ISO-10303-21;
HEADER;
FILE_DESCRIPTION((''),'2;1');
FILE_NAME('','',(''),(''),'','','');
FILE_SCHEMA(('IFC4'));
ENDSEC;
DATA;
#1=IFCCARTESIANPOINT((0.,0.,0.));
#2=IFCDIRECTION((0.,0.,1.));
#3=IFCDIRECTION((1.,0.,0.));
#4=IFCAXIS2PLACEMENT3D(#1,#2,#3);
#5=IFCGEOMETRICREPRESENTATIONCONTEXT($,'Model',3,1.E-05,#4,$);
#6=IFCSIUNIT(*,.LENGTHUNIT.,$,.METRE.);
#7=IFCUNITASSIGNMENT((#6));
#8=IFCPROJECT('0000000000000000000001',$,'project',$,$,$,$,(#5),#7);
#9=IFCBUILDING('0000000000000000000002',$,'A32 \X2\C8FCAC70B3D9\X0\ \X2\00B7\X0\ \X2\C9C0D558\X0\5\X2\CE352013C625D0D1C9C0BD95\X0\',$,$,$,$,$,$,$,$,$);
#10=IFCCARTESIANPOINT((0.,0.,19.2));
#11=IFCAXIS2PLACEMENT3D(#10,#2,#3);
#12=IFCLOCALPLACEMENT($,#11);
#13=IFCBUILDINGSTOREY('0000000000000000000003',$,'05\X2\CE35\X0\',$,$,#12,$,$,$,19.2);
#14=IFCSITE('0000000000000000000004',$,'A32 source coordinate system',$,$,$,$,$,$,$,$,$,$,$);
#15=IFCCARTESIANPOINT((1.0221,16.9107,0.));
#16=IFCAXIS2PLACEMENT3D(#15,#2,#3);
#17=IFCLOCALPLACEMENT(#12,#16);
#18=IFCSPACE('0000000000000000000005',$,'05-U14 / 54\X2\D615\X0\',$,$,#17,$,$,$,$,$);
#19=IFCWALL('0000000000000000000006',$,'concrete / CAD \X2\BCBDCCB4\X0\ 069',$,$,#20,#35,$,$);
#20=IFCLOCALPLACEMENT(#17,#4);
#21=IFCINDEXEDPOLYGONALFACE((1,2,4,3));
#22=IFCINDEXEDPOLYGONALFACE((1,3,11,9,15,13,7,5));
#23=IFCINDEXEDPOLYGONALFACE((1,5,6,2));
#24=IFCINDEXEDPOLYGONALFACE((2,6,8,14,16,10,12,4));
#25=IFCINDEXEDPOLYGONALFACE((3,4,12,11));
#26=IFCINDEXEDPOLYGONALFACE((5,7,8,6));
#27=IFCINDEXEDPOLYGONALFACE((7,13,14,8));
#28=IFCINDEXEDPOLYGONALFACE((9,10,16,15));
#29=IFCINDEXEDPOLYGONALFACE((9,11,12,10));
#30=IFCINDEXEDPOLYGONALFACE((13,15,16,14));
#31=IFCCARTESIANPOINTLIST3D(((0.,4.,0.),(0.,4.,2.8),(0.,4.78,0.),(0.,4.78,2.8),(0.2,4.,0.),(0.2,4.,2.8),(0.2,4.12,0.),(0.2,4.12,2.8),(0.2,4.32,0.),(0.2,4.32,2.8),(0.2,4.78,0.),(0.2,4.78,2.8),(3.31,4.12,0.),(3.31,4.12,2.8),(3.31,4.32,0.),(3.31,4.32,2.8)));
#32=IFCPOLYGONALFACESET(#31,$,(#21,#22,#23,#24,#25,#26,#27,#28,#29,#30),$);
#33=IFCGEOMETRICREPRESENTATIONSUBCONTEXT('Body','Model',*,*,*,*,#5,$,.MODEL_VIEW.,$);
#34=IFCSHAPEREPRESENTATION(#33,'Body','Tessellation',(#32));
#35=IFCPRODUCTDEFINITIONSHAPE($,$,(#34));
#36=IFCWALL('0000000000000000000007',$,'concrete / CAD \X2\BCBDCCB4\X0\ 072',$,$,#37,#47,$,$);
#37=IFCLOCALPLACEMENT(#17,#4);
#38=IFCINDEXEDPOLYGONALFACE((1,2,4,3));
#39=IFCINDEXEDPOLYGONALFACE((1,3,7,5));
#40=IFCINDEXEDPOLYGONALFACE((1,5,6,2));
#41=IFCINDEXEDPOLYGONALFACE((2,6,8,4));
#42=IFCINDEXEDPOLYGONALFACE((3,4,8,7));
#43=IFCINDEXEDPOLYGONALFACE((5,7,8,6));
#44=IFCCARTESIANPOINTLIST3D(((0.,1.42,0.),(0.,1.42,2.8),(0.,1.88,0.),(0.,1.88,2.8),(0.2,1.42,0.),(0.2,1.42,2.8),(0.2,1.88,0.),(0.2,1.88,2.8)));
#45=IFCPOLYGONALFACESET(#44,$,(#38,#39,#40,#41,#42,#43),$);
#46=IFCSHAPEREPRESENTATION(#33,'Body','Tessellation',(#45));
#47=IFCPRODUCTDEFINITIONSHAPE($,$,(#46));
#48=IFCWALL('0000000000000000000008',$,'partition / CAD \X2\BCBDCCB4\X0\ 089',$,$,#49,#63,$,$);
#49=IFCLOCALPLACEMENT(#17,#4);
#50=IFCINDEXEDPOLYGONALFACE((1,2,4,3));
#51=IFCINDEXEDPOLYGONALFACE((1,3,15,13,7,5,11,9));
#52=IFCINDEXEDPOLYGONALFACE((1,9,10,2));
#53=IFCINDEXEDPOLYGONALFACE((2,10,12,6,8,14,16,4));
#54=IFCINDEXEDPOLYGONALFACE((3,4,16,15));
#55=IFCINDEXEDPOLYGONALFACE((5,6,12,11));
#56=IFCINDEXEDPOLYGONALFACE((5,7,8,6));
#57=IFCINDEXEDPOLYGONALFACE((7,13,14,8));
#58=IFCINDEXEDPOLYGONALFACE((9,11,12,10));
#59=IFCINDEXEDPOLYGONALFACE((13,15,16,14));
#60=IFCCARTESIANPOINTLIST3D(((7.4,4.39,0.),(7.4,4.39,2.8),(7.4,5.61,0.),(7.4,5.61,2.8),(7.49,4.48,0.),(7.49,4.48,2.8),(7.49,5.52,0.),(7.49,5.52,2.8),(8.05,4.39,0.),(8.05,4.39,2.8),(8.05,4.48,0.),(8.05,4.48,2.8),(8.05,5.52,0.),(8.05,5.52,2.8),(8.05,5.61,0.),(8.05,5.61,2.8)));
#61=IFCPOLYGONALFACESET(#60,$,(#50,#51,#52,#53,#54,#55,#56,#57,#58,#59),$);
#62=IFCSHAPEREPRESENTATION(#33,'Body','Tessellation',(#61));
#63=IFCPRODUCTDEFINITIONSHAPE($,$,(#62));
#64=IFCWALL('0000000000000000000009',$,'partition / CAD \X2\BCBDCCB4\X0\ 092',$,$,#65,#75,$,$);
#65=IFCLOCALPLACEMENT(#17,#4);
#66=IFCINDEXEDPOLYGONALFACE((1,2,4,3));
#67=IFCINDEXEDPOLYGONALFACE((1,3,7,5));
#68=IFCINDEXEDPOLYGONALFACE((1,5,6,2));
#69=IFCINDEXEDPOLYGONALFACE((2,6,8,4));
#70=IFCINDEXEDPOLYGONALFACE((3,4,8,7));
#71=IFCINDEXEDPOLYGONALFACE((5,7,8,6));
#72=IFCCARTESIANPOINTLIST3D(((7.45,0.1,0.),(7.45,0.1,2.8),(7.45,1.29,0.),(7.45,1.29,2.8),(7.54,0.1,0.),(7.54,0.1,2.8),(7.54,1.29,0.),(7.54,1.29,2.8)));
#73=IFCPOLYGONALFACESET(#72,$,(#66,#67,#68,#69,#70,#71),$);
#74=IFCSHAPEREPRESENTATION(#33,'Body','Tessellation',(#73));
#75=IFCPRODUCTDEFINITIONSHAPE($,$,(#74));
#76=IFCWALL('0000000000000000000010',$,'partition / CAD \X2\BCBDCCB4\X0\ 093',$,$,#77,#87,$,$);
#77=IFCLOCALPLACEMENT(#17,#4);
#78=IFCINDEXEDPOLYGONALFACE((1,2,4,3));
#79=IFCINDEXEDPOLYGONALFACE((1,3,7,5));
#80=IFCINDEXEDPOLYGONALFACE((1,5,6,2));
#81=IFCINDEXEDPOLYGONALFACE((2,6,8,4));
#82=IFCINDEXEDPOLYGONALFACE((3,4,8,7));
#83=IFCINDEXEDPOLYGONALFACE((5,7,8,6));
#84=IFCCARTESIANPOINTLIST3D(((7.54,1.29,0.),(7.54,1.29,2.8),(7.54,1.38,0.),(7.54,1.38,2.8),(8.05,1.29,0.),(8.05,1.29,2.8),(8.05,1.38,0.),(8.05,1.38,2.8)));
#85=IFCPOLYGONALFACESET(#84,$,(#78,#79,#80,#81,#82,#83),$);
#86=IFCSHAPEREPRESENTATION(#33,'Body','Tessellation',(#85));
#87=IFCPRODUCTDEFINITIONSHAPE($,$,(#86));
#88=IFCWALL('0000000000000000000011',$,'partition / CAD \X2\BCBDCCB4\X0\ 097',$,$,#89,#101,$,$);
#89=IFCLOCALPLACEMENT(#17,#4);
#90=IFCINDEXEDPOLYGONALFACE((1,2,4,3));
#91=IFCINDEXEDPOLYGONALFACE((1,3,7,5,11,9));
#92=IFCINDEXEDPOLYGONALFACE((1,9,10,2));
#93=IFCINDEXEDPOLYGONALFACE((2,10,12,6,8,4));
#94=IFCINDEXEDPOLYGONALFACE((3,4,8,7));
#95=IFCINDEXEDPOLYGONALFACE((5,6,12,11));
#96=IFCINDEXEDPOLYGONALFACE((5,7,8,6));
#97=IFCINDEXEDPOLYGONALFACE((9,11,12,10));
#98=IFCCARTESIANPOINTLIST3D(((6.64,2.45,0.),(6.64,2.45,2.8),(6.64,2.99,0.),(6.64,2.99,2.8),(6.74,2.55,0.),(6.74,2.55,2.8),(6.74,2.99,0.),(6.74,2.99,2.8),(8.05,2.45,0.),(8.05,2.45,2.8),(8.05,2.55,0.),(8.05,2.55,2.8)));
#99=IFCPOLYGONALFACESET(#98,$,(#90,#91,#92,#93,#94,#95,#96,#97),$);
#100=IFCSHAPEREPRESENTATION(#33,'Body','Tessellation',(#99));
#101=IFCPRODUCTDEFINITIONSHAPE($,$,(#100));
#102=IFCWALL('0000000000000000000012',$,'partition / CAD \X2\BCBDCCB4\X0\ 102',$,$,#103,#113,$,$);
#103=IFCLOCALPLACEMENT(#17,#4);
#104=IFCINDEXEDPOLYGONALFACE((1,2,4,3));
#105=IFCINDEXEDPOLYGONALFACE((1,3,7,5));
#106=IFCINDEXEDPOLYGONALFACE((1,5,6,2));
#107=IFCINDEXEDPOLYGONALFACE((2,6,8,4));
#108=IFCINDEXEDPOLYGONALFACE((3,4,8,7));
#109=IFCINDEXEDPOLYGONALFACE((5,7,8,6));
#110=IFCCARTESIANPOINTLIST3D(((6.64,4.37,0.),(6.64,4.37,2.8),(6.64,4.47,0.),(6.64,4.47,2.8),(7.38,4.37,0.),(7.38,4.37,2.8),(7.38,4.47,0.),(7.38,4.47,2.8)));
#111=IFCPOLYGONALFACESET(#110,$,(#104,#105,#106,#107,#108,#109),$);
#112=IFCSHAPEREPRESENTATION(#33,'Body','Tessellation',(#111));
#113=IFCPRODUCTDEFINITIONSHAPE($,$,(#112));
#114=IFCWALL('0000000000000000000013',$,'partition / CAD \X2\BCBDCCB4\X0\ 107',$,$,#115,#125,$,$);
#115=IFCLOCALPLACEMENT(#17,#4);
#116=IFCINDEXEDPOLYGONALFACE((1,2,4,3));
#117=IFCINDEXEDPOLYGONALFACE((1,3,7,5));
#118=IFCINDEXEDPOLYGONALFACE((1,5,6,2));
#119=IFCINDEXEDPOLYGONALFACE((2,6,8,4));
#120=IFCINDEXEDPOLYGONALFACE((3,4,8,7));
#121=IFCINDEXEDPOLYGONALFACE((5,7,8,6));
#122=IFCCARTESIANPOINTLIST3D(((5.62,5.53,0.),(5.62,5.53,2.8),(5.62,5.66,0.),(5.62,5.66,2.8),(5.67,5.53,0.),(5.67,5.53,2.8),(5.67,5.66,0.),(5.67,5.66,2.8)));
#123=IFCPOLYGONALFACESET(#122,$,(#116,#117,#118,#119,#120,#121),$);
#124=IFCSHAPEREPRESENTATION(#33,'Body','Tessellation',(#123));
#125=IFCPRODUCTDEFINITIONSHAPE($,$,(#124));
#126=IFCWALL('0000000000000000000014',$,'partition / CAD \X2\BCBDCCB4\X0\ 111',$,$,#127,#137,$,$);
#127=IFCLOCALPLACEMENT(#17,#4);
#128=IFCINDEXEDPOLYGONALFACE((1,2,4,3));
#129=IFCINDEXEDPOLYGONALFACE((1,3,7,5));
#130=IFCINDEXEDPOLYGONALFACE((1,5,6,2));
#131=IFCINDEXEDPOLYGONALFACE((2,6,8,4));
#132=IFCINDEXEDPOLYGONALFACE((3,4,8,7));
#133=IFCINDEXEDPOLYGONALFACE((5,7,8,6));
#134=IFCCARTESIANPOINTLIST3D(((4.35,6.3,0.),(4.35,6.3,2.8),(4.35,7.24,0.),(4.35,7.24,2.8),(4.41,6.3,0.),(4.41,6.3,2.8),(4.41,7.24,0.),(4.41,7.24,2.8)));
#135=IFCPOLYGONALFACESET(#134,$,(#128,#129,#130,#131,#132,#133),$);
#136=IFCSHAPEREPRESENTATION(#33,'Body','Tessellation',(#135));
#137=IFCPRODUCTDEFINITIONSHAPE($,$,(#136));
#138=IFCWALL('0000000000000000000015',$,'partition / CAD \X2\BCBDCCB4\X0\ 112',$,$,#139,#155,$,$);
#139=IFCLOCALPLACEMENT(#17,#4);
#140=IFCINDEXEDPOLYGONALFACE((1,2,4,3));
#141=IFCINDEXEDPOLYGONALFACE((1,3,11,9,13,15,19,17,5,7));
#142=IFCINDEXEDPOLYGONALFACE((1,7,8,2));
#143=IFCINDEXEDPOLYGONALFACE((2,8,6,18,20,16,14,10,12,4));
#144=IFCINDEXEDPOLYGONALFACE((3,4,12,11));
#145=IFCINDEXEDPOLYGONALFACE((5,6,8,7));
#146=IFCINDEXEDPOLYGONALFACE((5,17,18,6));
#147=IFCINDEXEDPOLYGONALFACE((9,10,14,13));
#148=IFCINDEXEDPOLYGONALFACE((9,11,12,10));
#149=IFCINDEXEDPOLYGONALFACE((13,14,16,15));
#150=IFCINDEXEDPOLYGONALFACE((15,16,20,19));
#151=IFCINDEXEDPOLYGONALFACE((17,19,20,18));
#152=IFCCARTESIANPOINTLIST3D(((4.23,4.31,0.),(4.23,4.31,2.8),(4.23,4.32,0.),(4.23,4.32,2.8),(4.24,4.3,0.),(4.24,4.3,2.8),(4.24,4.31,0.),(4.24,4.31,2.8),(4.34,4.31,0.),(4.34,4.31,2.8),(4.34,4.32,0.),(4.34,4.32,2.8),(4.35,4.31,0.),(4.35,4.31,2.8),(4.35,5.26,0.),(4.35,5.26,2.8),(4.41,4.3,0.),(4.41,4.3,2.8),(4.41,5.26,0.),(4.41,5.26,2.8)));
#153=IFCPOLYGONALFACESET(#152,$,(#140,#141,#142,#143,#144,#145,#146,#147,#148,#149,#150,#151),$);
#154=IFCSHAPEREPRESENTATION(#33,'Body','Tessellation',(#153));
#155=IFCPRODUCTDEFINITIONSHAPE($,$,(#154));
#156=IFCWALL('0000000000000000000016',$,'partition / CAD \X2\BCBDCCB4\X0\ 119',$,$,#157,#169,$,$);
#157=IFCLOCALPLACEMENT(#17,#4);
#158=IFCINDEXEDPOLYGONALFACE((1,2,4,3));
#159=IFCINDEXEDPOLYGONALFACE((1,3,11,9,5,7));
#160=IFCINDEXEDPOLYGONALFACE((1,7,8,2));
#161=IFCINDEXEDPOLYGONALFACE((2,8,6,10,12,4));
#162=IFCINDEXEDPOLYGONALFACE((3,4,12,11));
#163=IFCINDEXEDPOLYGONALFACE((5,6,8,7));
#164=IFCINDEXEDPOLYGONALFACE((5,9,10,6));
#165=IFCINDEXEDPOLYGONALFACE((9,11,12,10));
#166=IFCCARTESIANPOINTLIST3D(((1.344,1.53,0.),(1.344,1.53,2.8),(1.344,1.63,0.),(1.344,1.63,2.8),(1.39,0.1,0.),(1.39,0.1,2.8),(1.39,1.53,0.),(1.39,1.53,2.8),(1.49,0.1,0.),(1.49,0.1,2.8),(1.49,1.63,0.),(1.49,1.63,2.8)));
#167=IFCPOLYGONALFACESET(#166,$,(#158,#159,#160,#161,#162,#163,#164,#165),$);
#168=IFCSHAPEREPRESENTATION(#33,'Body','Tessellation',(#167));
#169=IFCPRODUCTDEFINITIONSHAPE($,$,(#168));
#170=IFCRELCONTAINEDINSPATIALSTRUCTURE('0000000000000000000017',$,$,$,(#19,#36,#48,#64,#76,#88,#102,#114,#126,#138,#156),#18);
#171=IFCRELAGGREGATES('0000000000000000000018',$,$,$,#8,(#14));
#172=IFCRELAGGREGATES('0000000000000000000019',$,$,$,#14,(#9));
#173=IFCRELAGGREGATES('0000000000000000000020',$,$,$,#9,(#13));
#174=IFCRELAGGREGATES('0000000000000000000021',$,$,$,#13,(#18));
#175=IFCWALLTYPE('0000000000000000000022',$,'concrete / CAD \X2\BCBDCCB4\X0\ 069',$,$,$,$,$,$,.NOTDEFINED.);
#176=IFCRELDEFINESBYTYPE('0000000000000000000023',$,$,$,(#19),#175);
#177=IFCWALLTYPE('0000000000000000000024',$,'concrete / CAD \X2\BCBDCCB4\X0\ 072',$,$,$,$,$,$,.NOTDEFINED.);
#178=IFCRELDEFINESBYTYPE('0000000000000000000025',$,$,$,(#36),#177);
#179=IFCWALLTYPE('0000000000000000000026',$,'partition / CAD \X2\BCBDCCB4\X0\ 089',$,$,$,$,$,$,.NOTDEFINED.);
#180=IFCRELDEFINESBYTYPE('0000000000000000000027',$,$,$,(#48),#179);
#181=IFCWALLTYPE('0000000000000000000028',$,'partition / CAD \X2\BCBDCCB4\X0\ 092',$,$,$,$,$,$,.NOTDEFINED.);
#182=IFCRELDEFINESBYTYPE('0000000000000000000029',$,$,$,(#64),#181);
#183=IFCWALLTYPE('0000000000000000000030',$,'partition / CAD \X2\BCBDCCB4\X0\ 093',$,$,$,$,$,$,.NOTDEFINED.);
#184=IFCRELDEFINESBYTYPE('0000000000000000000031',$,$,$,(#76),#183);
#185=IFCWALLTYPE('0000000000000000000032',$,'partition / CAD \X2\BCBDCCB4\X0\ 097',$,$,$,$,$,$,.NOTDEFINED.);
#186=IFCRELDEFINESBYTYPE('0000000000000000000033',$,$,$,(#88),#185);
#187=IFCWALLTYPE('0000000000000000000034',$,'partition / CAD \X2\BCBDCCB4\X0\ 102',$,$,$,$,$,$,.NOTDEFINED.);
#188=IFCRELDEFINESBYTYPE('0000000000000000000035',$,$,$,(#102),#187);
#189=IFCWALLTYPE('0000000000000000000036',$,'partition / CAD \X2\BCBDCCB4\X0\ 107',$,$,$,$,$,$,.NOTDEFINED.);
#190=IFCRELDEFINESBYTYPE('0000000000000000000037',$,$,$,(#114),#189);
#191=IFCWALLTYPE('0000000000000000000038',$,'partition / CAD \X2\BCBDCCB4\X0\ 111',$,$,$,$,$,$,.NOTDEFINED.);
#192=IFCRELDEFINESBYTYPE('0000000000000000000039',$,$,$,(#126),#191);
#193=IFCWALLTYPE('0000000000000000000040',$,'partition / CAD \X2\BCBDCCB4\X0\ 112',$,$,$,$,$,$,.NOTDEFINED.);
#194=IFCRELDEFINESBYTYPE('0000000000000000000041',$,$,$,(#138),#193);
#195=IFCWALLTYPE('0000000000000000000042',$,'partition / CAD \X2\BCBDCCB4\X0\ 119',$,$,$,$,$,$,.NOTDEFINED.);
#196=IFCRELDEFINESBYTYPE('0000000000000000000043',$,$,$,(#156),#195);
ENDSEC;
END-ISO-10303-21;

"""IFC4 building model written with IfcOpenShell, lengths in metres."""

from ifc_helpers import new_model, si_unit, frame, origin, origin_with_axes, place, context, subcontext, project, spatial, polyline, outline, extrude, source, transform, mapped, type_object, type_shapes, element, save


model = new_model("IFC4")

# Units and contexts
model_context = context("Model", 3, precision=1e-05, world=origin_with_axes())
body_context = subcontext(model_context, "Body", "Model", "MODEL_VIEW")
ifc_project = project(units=[si_unit("LENGTHUNIT", "METRE")], contexts=[model_context])

# Site, building, storey, space
site = spatial("IfcSite", under=ifc_project, Name="A32 source coordinate system")
building = spatial("IfcBuilding", under=site, Name="A32 주거동 · 지하5층–옥탑지붕")
storey_placement = place(None, frame((0.0, 0.0, 19.2), z_axis=(0.0, 0.0, 1.0), x_axis=(1.0, 0.0, 0.0)))
storey = spatial("IfcBuildingStorey", under=building, at=storey_placement, Name="05층", Elevation=19.2)
space_placement = place(storey_placement, frame((1.0221, 16.9107, 0.0), z_axis=(0.0, 0.0, 1.0), x_axis=(1.0, 0.0, 0.0)))
space = spatial("IfcSpace", under=storey, at=space_placement, Name="05-U14 / 54형")

# Walls
wall_type_1 = type_object("IfcWallType", Name="concrete / CAD 벽체 069", PredefinedType="NOTDEFINED")
shared_shape_1 = source(origin(), body_context, "Body", "SweptSolid", [
    extrude(outline(polyline([(0.2, 4.12), (0.2, 4.0), (0.0, 4.0), (0.0, 4.78), (0.2, 4.78), (0.2, 4.32), (3.31, 4.32), (3.31, 4.12), (0.2, 4.12)])), origin(), (0.0, 0.0, 1.0), 2.8),
])
type_shapes(wall_type_1, [shared_shape_1])
wall_1_placement = place(space_placement, origin_with_axes())
element("IfcWall", 1, at=wall_1_placement, inside=space, type_object=wall_type_1, Name="concrete / CAD 벽체 069", context=body_context, shape_type="MappedRepresentation", body=[
    mapped(shared_shape_1, transform((0.0, 0.0, 0.0), scale=1.0)),
])
wall_type_2 = type_object("IfcWallType", Name="concrete / CAD 벽체 072", PredefinedType="NOTDEFINED")
shared_shape_2 = source(origin(), body_context, "Body", "SweptSolid", [
    extrude(outline(polyline([(0.2, 1.88), (0.2, 1.42), (0.0, 1.42), (0.0, 1.88), (0.2, 1.88)])), origin(), (0.0, 0.0, 1.0), 2.8),
])
type_shapes(wall_type_2, [shared_shape_2])
wall_2_placement = place(space_placement, origin_with_axes())
element("IfcWall", 2, at=wall_2_placement, inside=space, type_object=wall_type_2, Name="concrete / CAD 벽체 072", context=body_context, shape_type="MappedRepresentation", body=[
    mapped(shared_shape_2, transform((0.0, 0.0, 0.0), scale=1.0)),
])
wall_type_3 = type_object("IfcWallType", Name="partition / CAD 벽체 089", PredefinedType="NOTDEFINED")
shared_shape_3 = source(origin(), body_context, "Body", "SweptSolid", [
    extrude(outline(polyline([(7.49, 4.48), (8.05, 4.48), (8.05, 4.39), (7.4, 4.39), (7.4, 5.61), (8.05, 5.61), (8.05, 5.52), (7.49, 5.52), (7.49, 4.48)])), origin(), (0.0, 0.0, 1.0), 2.8),
])
type_shapes(wall_type_3, [shared_shape_3])
wall_3_placement = place(space_placement, origin_with_axes())
element("IfcWall", 3, at=wall_3_placement, inside=space, type_object=wall_type_3, Name="partition / CAD 벽체 089", context=body_context, shape_type="MappedRepresentation", body=[
    mapped(shared_shape_3, transform((0.0, 0.0, 0.0), scale=1.0)),
])
wall_type_4 = type_object("IfcWallType", Name="partition / CAD 벽체 092", PredefinedType="NOTDEFINED")
shared_shape_4 = source(origin(), body_context, "Body", "SweptSolid", [
    extrude(outline(polyline([(7.54, 1.29), (7.54, 0.1), (7.45, 0.1), (7.45, 1.29), (7.54, 1.29)])), origin(), (0.0, 0.0, 1.0), 2.8),
])
type_shapes(wall_type_4, [shared_shape_4])
wall_4_placement = place(space_placement, origin_with_axes())
element("IfcWall", 4, at=wall_4_placement, inside=space, type_object=wall_type_4, Name="partition / CAD 벽체 092", context=body_context, shape_type="MappedRepresentation", body=[
    mapped(shared_shape_4, transform((0.0, 0.0, 0.0), scale=1.0)),
])
wall_type_5 = type_object("IfcWallType", Name="partition / CAD 벽체 093", PredefinedType="NOTDEFINED")
shared_shape_5 = source(origin(), body_context, "Body", "SweptSolid", [
    extrude(outline(polyline([(8.05, 1.29), (7.54, 1.29), (7.54, 1.38), (8.05, 1.38), (8.05, 1.29)])), origin(), (0.0, 0.0, 1.0), 2.8),
])
type_shapes(wall_type_5, [shared_shape_5])
wall_5_placement = place(space_placement, origin_with_axes())
element("IfcWall", 5, at=wall_5_placement, inside=space, type_object=wall_type_5, Name="partition / CAD 벽체 093", context=body_context, shape_type="MappedRepresentation", body=[
    mapped(shared_shape_5, transform((0.0, 0.0, 0.0), scale=1.0)),
])
wall_type_6 = type_object("IfcWallType", Name="partition / CAD 벽체 097", PredefinedType="NOTDEFINED")
shared_shape_6 = source(origin(), body_context, "Body", "SweptSolid", [
    extrude(outline(polyline([(8.05, 2.45), (6.64, 2.45), (6.64, 2.99), (6.74, 2.99), (6.74, 2.55), (8.05, 2.55), (8.05, 2.45)])), origin(), (0.0, 0.0, 1.0), 2.8),
])
type_shapes(wall_type_6, [shared_shape_6])
wall_6_placement = place(space_placement, origin_with_axes())
element("IfcWall", 6, at=wall_6_placement, inside=space, type_object=wall_type_6, Name="partition / CAD 벽체 097", context=body_context, shape_type="MappedRepresentation", body=[
    mapped(shared_shape_6, transform((0.0, 0.0, 0.0), scale=1.0)),
])
wall_type_7 = type_object("IfcWallType", Name="partition / CAD 벽체 102", PredefinedType="NOTDEFINED")
shared_shape_7 = source(origin(), body_context, "Body", "SweptSolid", [
    extrude(outline(polyline([(7.38, 4.47), (7.38, 4.37), (6.64, 4.37), (6.64, 4.47), (7.38, 4.47)])), origin(), (0.0, 0.0, 1.0), 2.8),
])
type_shapes(wall_type_7, [shared_shape_7])
wall_7_placement = place(space_placement, origin_with_axes())
element("IfcWall", 7, at=wall_7_placement, inside=space, type_object=wall_type_7, Name="partition / CAD 벽체 102", context=body_context, shape_type="MappedRepresentation", body=[
    mapped(shared_shape_7, transform((0.0, 0.0, 0.0), scale=1.0)),
])
wall_type_8 = type_object("IfcWallType", Name="partition / CAD 벽체 107", PredefinedType="NOTDEFINED")
shared_shape_8 = source(origin(), body_context, "Body", "SweptSolid", [
    extrude(outline(polyline([(5.62, 5.53), (5.62, 5.66), (5.67, 5.66), (5.67, 5.53), (5.62, 5.53)])), origin(), (0.0, 0.0, 1.0), 2.8),
])
type_shapes(wall_type_8, [shared_shape_8])
wall_8_placement = place(space_placement, origin_with_axes())
element("IfcWall", 8, at=wall_8_placement, inside=space, type_object=wall_type_8, Name="partition / CAD 벽체 107", context=body_context, shape_type="MappedRepresentation", body=[
    mapped(shared_shape_8, transform((0.0, 0.0, 0.0), scale=1.0)),
])
wall_type_9 = type_object("IfcWallType", Name="partition / CAD 벽체 111", PredefinedType="NOTDEFINED")
shared_shape_9 = source(origin(), body_context, "Body", "SweptSolid", [
    extrude(outline(polyline([(4.41, 7.24), (4.41, 6.3), (4.35, 6.3), (4.35, 7.24), (4.41, 7.24)])), origin(), (0.0, 0.0, 1.0), 2.8),
])
type_shapes(wall_type_9, [shared_shape_9])
wall_9_placement = place(space_placement, origin_with_axes())
element("IfcWall", 9, at=wall_9_placement, inside=space, type_object=wall_type_9, Name="partition / CAD 벽체 111", context=body_context, shape_type="MappedRepresentation", body=[
    mapped(shared_shape_9, transform((0.0, 0.0, 0.0), scale=1.0)),
])
wall_type_10 = type_object("IfcWallType", Name="partition / CAD 벽체 112", PredefinedType="NOTDEFINED")
shared_shape_10 = source(origin(), body_context, "Body", "SweptSolid", [
    extrude(outline(polyline([(4.24, 4.3), (4.24, 4.31), (4.23, 4.31), (4.23, 4.32), (4.34, 4.32), (4.34, 4.31), (4.35, 4.31), (4.35, 5.26), (4.41, 5.26), (4.41, 4.3), (4.24, 4.3)])), origin(), (0.0, 0.0, 1.0), 2.8),
])
type_shapes(wall_type_10, [shared_shape_10])
wall_10_placement = place(space_placement, origin_with_axes())
element("IfcWall", 10, at=wall_10_placement, inside=space, type_object=wall_type_10, Name="partition / CAD 벽체 112", context=body_context, shape_type="MappedRepresentation", body=[
    mapped(shared_shape_10, transform((0.0, 0.0, 0.0), scale=1.0)),
])
wall_type_11 = type_object("IfcWallType", Name="partition / CAD 벽체 119", PredefinedType="NOTDEFINED")
shared_shape_11 = source(origin(), body_context, "Body", "SweptSolid", [
    extrude(outline(polyline([(1.344, 1.53), (1.344, 1.63), (1.49, 1.63), (1.49, 0.1), (1.39, 0.1), (1.39, 1.53), (1.344, 1.53)])), origin(), (0.0, 0.0, 1.0), 2.8),
])
type_shapes(wall_type_11, [shared_shape_11])
wall_11_placement = place(space_placement, origin_with_axes())
element("IfcWall", 11, at=wall_11_placement, inside=space, type_object=wall_type_11, Name="partition / CAD 벽체 119", context=body_context, shape_type="MappedRepresentation", body=[
    mapped(shared_shape_11, transform((0.0, 0.0, 0.0), scale=1.0)),
])

save(model, "model.ifc")
